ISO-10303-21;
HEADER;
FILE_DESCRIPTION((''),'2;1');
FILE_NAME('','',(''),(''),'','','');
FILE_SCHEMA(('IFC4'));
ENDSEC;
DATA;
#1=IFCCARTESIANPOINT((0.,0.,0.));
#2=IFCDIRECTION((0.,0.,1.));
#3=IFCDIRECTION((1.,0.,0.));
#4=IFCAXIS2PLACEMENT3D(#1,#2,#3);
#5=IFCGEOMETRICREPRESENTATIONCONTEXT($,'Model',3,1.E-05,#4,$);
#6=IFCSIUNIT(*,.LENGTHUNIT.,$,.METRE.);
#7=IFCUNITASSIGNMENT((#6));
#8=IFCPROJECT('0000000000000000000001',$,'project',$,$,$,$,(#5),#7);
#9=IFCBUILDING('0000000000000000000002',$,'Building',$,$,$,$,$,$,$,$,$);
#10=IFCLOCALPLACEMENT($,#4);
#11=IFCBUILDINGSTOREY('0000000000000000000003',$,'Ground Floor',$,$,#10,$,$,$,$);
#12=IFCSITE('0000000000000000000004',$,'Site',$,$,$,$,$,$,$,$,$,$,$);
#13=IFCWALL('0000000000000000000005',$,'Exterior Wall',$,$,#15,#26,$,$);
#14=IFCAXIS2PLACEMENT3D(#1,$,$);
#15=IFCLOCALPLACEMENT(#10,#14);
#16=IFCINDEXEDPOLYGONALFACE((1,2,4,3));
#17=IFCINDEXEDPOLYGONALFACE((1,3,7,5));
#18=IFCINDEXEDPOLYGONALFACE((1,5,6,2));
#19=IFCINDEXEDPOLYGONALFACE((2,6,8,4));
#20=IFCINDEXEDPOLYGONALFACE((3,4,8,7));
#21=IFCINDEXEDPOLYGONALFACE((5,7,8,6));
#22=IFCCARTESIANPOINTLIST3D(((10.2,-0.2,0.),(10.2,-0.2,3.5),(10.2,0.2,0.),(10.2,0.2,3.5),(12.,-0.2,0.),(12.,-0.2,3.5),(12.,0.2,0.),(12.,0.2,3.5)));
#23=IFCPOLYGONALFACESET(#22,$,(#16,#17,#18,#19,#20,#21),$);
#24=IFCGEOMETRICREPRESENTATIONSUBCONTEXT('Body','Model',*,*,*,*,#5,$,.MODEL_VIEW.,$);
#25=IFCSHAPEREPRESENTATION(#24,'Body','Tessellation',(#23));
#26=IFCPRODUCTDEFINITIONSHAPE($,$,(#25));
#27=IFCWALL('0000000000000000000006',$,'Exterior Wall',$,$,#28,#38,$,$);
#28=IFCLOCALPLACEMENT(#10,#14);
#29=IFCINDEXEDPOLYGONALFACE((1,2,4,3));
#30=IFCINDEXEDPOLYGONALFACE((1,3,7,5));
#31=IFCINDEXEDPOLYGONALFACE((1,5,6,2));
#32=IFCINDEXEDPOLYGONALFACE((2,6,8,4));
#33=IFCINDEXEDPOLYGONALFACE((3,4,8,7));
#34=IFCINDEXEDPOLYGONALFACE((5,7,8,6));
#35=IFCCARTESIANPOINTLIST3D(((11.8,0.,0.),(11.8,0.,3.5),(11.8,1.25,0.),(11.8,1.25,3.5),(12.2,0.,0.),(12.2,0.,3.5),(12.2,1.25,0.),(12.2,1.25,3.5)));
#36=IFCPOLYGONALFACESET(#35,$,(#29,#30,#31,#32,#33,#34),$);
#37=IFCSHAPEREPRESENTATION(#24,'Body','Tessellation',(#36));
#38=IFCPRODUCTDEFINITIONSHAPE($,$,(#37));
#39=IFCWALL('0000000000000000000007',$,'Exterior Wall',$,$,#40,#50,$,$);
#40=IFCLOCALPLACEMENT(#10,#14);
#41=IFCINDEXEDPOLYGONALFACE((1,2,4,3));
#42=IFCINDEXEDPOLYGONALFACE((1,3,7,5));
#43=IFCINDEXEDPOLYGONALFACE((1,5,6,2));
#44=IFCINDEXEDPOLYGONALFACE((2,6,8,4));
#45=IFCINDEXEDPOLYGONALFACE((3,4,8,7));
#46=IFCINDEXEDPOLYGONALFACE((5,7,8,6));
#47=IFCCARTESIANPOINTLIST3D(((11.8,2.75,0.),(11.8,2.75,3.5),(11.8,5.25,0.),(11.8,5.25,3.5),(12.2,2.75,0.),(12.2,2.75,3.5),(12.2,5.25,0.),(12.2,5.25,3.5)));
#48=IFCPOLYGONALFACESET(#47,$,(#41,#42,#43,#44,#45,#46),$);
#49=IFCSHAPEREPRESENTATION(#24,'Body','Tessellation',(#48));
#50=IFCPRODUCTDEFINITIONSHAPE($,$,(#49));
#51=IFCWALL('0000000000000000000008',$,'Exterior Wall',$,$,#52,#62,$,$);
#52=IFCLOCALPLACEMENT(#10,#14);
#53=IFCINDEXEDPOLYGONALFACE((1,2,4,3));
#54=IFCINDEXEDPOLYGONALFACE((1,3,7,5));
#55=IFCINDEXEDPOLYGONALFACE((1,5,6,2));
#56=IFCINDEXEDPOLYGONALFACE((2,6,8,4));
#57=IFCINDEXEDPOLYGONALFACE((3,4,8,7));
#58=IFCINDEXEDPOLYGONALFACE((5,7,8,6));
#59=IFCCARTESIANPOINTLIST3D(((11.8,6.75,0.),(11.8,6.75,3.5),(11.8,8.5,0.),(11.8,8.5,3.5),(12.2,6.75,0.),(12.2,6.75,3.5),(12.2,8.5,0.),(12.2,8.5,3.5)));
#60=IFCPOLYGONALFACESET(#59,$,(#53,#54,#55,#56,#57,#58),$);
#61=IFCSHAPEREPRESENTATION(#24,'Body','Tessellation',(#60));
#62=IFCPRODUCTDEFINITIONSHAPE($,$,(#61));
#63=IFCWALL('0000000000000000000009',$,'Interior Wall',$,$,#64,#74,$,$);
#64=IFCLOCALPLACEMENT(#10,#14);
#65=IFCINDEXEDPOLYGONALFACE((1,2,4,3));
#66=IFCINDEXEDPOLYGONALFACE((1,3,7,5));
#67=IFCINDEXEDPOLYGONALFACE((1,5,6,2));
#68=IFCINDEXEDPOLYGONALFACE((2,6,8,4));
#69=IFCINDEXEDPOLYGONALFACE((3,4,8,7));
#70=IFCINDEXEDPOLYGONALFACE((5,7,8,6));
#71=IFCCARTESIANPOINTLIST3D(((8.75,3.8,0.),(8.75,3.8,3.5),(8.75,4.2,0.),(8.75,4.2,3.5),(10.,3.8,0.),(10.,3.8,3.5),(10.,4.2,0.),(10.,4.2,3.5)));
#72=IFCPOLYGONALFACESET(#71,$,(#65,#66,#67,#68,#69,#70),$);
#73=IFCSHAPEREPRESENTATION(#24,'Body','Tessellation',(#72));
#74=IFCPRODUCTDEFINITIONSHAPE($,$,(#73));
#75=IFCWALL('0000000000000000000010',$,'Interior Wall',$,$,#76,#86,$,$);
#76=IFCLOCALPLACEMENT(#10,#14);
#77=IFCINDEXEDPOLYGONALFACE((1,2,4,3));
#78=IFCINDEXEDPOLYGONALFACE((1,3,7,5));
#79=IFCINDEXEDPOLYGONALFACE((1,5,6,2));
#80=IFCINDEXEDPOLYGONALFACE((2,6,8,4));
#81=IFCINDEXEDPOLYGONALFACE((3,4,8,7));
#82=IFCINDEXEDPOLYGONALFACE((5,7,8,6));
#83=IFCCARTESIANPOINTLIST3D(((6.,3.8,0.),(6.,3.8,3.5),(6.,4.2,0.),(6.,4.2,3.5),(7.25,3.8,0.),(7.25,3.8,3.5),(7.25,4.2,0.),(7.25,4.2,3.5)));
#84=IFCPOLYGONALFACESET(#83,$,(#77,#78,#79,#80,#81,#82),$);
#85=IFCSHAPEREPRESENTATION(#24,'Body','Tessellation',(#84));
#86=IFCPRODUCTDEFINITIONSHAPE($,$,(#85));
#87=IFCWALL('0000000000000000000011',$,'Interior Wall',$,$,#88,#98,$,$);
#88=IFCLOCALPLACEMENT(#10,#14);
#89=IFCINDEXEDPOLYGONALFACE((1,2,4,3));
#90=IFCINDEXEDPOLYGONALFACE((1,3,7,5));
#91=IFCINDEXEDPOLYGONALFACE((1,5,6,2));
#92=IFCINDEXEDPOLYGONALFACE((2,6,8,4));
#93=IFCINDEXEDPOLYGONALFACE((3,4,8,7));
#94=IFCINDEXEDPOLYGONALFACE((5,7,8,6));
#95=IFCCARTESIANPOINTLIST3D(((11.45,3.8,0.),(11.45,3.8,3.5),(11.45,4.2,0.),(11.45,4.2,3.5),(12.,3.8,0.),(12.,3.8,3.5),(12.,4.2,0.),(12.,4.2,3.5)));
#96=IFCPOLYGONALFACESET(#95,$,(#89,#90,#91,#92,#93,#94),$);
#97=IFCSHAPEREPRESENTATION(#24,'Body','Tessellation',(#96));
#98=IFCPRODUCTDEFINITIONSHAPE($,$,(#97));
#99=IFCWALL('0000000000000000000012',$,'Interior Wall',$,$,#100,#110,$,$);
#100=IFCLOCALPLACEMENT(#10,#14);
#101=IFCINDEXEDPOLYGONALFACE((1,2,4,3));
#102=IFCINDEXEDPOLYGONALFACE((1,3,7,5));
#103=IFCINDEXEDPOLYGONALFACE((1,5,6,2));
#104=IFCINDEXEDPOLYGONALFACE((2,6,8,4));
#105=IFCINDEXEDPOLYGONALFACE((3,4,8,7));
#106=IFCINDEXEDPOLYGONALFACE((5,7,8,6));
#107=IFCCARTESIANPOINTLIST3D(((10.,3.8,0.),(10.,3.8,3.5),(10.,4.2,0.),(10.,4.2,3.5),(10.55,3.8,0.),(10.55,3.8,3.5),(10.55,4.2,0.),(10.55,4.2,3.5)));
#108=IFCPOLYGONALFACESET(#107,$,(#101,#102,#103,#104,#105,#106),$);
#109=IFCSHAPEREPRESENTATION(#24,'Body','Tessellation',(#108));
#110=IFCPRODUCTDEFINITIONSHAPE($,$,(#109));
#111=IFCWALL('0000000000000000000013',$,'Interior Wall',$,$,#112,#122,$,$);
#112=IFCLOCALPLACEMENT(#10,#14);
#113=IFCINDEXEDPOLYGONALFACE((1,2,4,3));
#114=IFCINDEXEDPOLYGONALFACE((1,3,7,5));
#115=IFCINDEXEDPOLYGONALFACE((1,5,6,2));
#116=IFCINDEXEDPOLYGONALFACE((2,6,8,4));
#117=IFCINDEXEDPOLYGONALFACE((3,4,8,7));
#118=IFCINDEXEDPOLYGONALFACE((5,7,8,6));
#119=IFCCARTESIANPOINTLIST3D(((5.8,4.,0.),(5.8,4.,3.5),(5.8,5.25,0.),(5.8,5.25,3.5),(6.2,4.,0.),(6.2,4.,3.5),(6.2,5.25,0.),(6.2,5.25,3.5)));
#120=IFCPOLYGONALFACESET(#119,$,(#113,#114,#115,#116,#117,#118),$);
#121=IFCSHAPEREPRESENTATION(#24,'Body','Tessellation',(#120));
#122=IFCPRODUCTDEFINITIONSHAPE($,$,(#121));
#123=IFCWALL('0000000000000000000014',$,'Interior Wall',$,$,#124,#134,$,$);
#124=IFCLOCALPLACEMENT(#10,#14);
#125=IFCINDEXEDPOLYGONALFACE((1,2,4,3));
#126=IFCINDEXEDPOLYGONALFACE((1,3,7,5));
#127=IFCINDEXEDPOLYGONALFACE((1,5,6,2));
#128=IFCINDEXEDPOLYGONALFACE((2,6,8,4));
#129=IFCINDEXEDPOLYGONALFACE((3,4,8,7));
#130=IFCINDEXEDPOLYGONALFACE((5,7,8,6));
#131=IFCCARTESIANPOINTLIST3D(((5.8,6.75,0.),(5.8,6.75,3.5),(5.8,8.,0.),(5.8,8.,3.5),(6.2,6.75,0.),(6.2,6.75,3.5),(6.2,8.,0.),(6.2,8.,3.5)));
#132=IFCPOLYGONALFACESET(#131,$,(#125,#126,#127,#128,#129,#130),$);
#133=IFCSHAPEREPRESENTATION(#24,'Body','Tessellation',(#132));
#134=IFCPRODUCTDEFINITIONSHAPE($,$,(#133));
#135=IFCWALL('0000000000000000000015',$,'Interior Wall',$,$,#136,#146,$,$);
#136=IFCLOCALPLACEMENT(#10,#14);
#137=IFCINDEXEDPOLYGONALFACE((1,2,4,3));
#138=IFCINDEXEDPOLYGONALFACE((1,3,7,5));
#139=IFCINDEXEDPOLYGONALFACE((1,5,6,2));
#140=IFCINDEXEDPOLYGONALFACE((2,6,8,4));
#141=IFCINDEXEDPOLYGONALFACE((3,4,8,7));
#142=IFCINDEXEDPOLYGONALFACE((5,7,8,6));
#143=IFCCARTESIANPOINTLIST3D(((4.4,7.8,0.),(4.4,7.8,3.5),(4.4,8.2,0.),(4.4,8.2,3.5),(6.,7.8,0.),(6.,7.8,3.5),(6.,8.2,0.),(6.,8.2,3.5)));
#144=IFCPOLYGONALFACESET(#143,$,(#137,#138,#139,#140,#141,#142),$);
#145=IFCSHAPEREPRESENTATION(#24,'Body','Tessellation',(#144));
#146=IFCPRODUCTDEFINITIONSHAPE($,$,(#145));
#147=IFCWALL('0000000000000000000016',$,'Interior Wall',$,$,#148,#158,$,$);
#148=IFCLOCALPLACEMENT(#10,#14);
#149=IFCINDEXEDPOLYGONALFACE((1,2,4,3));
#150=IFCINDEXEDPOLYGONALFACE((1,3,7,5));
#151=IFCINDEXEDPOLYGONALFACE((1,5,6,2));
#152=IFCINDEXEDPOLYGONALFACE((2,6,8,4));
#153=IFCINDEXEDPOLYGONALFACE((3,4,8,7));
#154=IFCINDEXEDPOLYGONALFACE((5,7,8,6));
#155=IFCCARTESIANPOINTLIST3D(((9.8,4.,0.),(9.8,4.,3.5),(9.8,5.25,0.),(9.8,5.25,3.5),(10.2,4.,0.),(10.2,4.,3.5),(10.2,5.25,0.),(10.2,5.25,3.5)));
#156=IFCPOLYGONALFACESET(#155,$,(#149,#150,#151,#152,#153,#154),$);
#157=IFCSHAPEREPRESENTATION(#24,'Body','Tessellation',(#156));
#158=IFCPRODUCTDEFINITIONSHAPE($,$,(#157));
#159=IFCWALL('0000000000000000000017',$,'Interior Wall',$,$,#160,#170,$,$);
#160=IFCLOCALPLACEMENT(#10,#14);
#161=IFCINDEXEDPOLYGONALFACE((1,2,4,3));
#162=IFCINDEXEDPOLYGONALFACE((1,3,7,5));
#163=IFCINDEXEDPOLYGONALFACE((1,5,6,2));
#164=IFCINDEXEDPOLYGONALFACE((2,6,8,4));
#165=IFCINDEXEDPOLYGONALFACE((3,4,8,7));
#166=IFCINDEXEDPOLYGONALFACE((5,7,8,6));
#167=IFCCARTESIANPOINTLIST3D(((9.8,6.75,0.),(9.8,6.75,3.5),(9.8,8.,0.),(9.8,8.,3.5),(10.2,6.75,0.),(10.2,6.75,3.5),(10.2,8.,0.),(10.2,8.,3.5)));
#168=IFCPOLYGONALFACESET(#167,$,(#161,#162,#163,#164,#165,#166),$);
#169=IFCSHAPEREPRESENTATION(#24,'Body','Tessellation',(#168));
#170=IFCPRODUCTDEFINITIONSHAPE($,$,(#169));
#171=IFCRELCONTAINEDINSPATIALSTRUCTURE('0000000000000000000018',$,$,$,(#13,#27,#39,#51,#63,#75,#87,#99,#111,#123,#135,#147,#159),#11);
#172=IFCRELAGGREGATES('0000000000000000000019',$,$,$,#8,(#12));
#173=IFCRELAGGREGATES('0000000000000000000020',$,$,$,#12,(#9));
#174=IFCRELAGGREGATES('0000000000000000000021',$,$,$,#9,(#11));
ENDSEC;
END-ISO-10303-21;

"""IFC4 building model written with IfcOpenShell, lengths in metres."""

from ifc_helpers import new_model, si_unit, frame, origin_with_axes, place, context, subcontext, project, spatial, indexed_curve, outline, extrude, element, save


model = new_model("IFC4")

# Units and contexts
model_context = context("Model", 3, precision=1e-05, world=origin_with_axes())
body_context = subcontext(model_context, "Body", "Model", "MODEL_VIEW")
ifc_project = project(units=[si_unit("LENGTHUNIT", "METRE")], contexts=[model_context])

# Site, building, storey
site = spatial("IfcSite", under=ifc_project, Name="Site")
building = spatial("IfcBuilding", under=site, Name="Building")
storey_placement = place(None, origin_with_axes())
storey = spatial("IfcBuildingStorey", under=building, at=storey_placement, Name="Ground Floor")

# Walls
wall_1_placement = place(storey_placement, frame((10.2, 0.0, 0.0), z_axis=(0.0, 0.0, 1.0), x_axis=(1.0, 0.0, 0.0)))
element("IfcWall", 1, at=wall_1_placement, inside=storey, Name="Exterior Wall", context=body_context, shape_type="SweptSolid", body=[
    extrude(outline(indexed_curve([(0.0, 0.0), (0.0, 0.4), (1.8, 0.4), (1.8, 0.0), (0.0, 0.0)], self_intersect=False)), frame((0.0, -0.2, 0.0), z_axis=(0.0, 0.0, 1.0), x_axis=(1.0, 0.0, 0.0)), (0.0, 0.0, 1.0), 3.5),
])
wall_2_placement = place(storey_placement, frame((12.0, 0.0, 0.0), z_axis=(0.0, 0.0, 1.0), x_axis=(0.0, 1.0, 0.0)))
element("IfcWall", 2, at=wall_2_placement, inside=storey, Name="Exterior Wall", context=body_context, shape_type="SweptSolid", body=[
    extrude(outline(indexed_curve([(0.0, 0.0), (0.0, 0.4), (1.25, 0.4), (1.25, 0.0), (0.0, 0.0)], self_intersect=False)), frame((0.0, -0.2, 0.0), z_axis=(0.0, 0.0, 1.0), x_axis=(1.0, 0.0, 0.0)), (0.0, 0.0, 1.0), 3.5),
])
wall_3_placement = place(storey_placement, frame((12.0, 2.75, 0.0), z_axis=(0.0, 0.0, 1.0), x_axis=(0.0, 1.0, 0.0)))
element("IfcWall", 3, at=wall_3_placement, inside=storey, Name="Exterior Wall", context=body_context, shape_type="SweptSolid", body=[
    extrude(outline(indexed_curve([(0.0, 0.0), (0.0, 0.4), (2.5, 0.4), (2.5, 0.0), (0.0, 0.0)], self_intersect=False)), frame((0.0, -0.2, 0.0), z_axis=(0.0, 0.0, 1.0), x_axis=(1.0, 0.0, 0.0)), (0.0, 0.0, 1.0), 3.5),
])
wall_4_placement = place(storey_placement, frame((12.0, 6.75, 0.0), z_axis=(0.0, 0.0, 1.0), x_axis=(0.0, 1.0, 0.0)))
element("IfcWall", 4, at=wall_4_placement, inside=storey, Name="Exterior Wall", context=body_context, shape_type="SweptSolid", body=[
    extrude(outline(indexed_curve([(0.0, 0.0), (0.0, 0.4), (1.75, 0.4), (1.75, 0.0), (0.0, 0.0)], self_intersect=False)), frame((0.0, -0.2, 0.0), z_axis=(0.0, 0.0, 1.0), x_axis=(1.0, 0.0, 0.0)), (0.0, 0.0, 1.0), 3.5),
])
for number, where, z_axis, x_axis, name in (
    (5, (10.0, 4.0, 0.0), (0.0, 0.0, 1.0), (-1.0, 0.0, 0.0), "Interior Wall"),
    (6, (7.25, 4.0, 0.0), (0.0, 0.0, 1.0), (-1.0, 0.0, 0.0), "Interior Wall"),
):
    element("IfcWall", number, at=place(storey_placement, frame(where, z_axis=z_axis, x_axis=x_axis)), inside=storey, Name=name, context=body_context, shape_type="SweptSolid", body=[
        extrude(outline(indexed_curve([(0.0, 0.0), (0.0, 0.4), (1.25, 0.4), (1.25, 0.0), (0.0, 0.0)], self_intersect=False)), frame((0.0, -0.2, 0.0), z_axis=(0.0, 0.0, 1.0), x_axis=(1.0, 0.0, 0.0)), (0.0, 0.0, 1.0), 3.5),
    ])
for number, where, z_axis, x_axis, name in (
    (7, (12.0, 4.0, 0.0), (0.0, 0.0, 1.0), (-1.0, 0.0, 0.0), "Interior Wall"),
    (8, (10.55, 4.0, 0.0), (0.0, 0.0, 1.0), (-1.0, 0.0, 0.0), "Interior Wall"),
):
    element("IfcWall", number, at=place(storey_placement, frame(where, z_axis=z_axis, x_axis=x_axis)), inside=storey, Name=name, context=body_context, shape_type="SweptSolid", body=[
        extrude(outline(indexed_curve([(0.0, 0.0), (0.0, 0.4), (0.55, 0.4), (0.55, 0.0), (0.0, 0.0)], self_intersect=False)), frame((0.0, -0.2, 0.0), z_axis=(0.0, 0.0, 1.0), x_axis=(1.0, 0.0, 0.0)), (0.0, 0.0, 1.0), 3.5),
    ])
for number, where, z_axis, x_axis, name in (
    (9, (6.0, 4.0, 0.0), (0.0, 0.0, 1.0), (0.0, 1.0, 0.0), "Interior Wall"),
    (10, (6.0, 6.75, 0.0), (0.0, 0.0, 1.0), (0.0, 1.0, 0.0), "Interior Wall"),
):
    element("IfcWall", number, at=place(storey_placement, frame(where, z_axis=z_axis, x_axis=x_axis)), inside=storey, Name=name, context=body_context, shape_type="SweptSolid", body=[
        extrude(outline(indexed_curve([(0.0, 0.0), (0.0, 0.4), (1.25, 0.4), (1.25, 0.0), (0.0, 0.0)], self_intersect=False)), frame((0.0, -0.2, 0.0), z_axis=(0.0, 0.0, 1.0), x_axis=(1.0, 0.0, 0.0)), (0.0, 0.0, 1.0), 3.5),
    ])
wall_5_placement = place(storey_placement, frame((6.0, 8.0, 0.0), z_axis=(0.0, 0.0, 1.0), x_axis=(-1.0, 0.0, 0.0)))
element("IfcWall", 11, at=wall_5_placement, inside=storey, Name="Interior Wall", context=body_context, shape_type="SweptSolid", body=[
    extrude(outline(indexed_curve([(0.0, 0.0), (0.0, 0.4), (1.6, 0.4), (1.6, 0.0), (0.0, 0.0)], self_intersect=False)), frame((0.0, -0.2, 0.0), z_axis=(0.0, 0.0, 1.0), x_axis=(1.0, 0.0, 0.0)), (0.0, 0.0, 1.0), 3.5),
])
for number, where, z_axis, x_axis, name in (
    (12, (10.0, 4.0, 0.0), (0.0, 0.0, 1.0), (0.0, 1.0, 0.0), "Interior Wall"),
    (13, (10.0, 6.75, 0.0), (0.0, 0.0, 1.0), (0.0, 1.0, 0.0), "Interior Wall"),
):
    element("IfcWall", number, at=place(storey_placement, frame(where, z_axis=z_axis, x_axis=x_axis)), inside=storey, Name=name, context=body_context, shape_type="SweptSolid", body=[
        extrude(outline(indexed_curve([(0.0, 0.0), (0.0, 0.4), (1.25, 0.4), (1.25, 0.0), (0.0, 0.0)], self_intersect=False)), frame((0.0, -0.2, 0.0), z_axis=(0.0, 0.0, 1.0), x_axis=(1.0, 0.0, 0.0)), (0.0, 0.0, 1.0), 3.5),
    ])

save(model, "model.ifc")
